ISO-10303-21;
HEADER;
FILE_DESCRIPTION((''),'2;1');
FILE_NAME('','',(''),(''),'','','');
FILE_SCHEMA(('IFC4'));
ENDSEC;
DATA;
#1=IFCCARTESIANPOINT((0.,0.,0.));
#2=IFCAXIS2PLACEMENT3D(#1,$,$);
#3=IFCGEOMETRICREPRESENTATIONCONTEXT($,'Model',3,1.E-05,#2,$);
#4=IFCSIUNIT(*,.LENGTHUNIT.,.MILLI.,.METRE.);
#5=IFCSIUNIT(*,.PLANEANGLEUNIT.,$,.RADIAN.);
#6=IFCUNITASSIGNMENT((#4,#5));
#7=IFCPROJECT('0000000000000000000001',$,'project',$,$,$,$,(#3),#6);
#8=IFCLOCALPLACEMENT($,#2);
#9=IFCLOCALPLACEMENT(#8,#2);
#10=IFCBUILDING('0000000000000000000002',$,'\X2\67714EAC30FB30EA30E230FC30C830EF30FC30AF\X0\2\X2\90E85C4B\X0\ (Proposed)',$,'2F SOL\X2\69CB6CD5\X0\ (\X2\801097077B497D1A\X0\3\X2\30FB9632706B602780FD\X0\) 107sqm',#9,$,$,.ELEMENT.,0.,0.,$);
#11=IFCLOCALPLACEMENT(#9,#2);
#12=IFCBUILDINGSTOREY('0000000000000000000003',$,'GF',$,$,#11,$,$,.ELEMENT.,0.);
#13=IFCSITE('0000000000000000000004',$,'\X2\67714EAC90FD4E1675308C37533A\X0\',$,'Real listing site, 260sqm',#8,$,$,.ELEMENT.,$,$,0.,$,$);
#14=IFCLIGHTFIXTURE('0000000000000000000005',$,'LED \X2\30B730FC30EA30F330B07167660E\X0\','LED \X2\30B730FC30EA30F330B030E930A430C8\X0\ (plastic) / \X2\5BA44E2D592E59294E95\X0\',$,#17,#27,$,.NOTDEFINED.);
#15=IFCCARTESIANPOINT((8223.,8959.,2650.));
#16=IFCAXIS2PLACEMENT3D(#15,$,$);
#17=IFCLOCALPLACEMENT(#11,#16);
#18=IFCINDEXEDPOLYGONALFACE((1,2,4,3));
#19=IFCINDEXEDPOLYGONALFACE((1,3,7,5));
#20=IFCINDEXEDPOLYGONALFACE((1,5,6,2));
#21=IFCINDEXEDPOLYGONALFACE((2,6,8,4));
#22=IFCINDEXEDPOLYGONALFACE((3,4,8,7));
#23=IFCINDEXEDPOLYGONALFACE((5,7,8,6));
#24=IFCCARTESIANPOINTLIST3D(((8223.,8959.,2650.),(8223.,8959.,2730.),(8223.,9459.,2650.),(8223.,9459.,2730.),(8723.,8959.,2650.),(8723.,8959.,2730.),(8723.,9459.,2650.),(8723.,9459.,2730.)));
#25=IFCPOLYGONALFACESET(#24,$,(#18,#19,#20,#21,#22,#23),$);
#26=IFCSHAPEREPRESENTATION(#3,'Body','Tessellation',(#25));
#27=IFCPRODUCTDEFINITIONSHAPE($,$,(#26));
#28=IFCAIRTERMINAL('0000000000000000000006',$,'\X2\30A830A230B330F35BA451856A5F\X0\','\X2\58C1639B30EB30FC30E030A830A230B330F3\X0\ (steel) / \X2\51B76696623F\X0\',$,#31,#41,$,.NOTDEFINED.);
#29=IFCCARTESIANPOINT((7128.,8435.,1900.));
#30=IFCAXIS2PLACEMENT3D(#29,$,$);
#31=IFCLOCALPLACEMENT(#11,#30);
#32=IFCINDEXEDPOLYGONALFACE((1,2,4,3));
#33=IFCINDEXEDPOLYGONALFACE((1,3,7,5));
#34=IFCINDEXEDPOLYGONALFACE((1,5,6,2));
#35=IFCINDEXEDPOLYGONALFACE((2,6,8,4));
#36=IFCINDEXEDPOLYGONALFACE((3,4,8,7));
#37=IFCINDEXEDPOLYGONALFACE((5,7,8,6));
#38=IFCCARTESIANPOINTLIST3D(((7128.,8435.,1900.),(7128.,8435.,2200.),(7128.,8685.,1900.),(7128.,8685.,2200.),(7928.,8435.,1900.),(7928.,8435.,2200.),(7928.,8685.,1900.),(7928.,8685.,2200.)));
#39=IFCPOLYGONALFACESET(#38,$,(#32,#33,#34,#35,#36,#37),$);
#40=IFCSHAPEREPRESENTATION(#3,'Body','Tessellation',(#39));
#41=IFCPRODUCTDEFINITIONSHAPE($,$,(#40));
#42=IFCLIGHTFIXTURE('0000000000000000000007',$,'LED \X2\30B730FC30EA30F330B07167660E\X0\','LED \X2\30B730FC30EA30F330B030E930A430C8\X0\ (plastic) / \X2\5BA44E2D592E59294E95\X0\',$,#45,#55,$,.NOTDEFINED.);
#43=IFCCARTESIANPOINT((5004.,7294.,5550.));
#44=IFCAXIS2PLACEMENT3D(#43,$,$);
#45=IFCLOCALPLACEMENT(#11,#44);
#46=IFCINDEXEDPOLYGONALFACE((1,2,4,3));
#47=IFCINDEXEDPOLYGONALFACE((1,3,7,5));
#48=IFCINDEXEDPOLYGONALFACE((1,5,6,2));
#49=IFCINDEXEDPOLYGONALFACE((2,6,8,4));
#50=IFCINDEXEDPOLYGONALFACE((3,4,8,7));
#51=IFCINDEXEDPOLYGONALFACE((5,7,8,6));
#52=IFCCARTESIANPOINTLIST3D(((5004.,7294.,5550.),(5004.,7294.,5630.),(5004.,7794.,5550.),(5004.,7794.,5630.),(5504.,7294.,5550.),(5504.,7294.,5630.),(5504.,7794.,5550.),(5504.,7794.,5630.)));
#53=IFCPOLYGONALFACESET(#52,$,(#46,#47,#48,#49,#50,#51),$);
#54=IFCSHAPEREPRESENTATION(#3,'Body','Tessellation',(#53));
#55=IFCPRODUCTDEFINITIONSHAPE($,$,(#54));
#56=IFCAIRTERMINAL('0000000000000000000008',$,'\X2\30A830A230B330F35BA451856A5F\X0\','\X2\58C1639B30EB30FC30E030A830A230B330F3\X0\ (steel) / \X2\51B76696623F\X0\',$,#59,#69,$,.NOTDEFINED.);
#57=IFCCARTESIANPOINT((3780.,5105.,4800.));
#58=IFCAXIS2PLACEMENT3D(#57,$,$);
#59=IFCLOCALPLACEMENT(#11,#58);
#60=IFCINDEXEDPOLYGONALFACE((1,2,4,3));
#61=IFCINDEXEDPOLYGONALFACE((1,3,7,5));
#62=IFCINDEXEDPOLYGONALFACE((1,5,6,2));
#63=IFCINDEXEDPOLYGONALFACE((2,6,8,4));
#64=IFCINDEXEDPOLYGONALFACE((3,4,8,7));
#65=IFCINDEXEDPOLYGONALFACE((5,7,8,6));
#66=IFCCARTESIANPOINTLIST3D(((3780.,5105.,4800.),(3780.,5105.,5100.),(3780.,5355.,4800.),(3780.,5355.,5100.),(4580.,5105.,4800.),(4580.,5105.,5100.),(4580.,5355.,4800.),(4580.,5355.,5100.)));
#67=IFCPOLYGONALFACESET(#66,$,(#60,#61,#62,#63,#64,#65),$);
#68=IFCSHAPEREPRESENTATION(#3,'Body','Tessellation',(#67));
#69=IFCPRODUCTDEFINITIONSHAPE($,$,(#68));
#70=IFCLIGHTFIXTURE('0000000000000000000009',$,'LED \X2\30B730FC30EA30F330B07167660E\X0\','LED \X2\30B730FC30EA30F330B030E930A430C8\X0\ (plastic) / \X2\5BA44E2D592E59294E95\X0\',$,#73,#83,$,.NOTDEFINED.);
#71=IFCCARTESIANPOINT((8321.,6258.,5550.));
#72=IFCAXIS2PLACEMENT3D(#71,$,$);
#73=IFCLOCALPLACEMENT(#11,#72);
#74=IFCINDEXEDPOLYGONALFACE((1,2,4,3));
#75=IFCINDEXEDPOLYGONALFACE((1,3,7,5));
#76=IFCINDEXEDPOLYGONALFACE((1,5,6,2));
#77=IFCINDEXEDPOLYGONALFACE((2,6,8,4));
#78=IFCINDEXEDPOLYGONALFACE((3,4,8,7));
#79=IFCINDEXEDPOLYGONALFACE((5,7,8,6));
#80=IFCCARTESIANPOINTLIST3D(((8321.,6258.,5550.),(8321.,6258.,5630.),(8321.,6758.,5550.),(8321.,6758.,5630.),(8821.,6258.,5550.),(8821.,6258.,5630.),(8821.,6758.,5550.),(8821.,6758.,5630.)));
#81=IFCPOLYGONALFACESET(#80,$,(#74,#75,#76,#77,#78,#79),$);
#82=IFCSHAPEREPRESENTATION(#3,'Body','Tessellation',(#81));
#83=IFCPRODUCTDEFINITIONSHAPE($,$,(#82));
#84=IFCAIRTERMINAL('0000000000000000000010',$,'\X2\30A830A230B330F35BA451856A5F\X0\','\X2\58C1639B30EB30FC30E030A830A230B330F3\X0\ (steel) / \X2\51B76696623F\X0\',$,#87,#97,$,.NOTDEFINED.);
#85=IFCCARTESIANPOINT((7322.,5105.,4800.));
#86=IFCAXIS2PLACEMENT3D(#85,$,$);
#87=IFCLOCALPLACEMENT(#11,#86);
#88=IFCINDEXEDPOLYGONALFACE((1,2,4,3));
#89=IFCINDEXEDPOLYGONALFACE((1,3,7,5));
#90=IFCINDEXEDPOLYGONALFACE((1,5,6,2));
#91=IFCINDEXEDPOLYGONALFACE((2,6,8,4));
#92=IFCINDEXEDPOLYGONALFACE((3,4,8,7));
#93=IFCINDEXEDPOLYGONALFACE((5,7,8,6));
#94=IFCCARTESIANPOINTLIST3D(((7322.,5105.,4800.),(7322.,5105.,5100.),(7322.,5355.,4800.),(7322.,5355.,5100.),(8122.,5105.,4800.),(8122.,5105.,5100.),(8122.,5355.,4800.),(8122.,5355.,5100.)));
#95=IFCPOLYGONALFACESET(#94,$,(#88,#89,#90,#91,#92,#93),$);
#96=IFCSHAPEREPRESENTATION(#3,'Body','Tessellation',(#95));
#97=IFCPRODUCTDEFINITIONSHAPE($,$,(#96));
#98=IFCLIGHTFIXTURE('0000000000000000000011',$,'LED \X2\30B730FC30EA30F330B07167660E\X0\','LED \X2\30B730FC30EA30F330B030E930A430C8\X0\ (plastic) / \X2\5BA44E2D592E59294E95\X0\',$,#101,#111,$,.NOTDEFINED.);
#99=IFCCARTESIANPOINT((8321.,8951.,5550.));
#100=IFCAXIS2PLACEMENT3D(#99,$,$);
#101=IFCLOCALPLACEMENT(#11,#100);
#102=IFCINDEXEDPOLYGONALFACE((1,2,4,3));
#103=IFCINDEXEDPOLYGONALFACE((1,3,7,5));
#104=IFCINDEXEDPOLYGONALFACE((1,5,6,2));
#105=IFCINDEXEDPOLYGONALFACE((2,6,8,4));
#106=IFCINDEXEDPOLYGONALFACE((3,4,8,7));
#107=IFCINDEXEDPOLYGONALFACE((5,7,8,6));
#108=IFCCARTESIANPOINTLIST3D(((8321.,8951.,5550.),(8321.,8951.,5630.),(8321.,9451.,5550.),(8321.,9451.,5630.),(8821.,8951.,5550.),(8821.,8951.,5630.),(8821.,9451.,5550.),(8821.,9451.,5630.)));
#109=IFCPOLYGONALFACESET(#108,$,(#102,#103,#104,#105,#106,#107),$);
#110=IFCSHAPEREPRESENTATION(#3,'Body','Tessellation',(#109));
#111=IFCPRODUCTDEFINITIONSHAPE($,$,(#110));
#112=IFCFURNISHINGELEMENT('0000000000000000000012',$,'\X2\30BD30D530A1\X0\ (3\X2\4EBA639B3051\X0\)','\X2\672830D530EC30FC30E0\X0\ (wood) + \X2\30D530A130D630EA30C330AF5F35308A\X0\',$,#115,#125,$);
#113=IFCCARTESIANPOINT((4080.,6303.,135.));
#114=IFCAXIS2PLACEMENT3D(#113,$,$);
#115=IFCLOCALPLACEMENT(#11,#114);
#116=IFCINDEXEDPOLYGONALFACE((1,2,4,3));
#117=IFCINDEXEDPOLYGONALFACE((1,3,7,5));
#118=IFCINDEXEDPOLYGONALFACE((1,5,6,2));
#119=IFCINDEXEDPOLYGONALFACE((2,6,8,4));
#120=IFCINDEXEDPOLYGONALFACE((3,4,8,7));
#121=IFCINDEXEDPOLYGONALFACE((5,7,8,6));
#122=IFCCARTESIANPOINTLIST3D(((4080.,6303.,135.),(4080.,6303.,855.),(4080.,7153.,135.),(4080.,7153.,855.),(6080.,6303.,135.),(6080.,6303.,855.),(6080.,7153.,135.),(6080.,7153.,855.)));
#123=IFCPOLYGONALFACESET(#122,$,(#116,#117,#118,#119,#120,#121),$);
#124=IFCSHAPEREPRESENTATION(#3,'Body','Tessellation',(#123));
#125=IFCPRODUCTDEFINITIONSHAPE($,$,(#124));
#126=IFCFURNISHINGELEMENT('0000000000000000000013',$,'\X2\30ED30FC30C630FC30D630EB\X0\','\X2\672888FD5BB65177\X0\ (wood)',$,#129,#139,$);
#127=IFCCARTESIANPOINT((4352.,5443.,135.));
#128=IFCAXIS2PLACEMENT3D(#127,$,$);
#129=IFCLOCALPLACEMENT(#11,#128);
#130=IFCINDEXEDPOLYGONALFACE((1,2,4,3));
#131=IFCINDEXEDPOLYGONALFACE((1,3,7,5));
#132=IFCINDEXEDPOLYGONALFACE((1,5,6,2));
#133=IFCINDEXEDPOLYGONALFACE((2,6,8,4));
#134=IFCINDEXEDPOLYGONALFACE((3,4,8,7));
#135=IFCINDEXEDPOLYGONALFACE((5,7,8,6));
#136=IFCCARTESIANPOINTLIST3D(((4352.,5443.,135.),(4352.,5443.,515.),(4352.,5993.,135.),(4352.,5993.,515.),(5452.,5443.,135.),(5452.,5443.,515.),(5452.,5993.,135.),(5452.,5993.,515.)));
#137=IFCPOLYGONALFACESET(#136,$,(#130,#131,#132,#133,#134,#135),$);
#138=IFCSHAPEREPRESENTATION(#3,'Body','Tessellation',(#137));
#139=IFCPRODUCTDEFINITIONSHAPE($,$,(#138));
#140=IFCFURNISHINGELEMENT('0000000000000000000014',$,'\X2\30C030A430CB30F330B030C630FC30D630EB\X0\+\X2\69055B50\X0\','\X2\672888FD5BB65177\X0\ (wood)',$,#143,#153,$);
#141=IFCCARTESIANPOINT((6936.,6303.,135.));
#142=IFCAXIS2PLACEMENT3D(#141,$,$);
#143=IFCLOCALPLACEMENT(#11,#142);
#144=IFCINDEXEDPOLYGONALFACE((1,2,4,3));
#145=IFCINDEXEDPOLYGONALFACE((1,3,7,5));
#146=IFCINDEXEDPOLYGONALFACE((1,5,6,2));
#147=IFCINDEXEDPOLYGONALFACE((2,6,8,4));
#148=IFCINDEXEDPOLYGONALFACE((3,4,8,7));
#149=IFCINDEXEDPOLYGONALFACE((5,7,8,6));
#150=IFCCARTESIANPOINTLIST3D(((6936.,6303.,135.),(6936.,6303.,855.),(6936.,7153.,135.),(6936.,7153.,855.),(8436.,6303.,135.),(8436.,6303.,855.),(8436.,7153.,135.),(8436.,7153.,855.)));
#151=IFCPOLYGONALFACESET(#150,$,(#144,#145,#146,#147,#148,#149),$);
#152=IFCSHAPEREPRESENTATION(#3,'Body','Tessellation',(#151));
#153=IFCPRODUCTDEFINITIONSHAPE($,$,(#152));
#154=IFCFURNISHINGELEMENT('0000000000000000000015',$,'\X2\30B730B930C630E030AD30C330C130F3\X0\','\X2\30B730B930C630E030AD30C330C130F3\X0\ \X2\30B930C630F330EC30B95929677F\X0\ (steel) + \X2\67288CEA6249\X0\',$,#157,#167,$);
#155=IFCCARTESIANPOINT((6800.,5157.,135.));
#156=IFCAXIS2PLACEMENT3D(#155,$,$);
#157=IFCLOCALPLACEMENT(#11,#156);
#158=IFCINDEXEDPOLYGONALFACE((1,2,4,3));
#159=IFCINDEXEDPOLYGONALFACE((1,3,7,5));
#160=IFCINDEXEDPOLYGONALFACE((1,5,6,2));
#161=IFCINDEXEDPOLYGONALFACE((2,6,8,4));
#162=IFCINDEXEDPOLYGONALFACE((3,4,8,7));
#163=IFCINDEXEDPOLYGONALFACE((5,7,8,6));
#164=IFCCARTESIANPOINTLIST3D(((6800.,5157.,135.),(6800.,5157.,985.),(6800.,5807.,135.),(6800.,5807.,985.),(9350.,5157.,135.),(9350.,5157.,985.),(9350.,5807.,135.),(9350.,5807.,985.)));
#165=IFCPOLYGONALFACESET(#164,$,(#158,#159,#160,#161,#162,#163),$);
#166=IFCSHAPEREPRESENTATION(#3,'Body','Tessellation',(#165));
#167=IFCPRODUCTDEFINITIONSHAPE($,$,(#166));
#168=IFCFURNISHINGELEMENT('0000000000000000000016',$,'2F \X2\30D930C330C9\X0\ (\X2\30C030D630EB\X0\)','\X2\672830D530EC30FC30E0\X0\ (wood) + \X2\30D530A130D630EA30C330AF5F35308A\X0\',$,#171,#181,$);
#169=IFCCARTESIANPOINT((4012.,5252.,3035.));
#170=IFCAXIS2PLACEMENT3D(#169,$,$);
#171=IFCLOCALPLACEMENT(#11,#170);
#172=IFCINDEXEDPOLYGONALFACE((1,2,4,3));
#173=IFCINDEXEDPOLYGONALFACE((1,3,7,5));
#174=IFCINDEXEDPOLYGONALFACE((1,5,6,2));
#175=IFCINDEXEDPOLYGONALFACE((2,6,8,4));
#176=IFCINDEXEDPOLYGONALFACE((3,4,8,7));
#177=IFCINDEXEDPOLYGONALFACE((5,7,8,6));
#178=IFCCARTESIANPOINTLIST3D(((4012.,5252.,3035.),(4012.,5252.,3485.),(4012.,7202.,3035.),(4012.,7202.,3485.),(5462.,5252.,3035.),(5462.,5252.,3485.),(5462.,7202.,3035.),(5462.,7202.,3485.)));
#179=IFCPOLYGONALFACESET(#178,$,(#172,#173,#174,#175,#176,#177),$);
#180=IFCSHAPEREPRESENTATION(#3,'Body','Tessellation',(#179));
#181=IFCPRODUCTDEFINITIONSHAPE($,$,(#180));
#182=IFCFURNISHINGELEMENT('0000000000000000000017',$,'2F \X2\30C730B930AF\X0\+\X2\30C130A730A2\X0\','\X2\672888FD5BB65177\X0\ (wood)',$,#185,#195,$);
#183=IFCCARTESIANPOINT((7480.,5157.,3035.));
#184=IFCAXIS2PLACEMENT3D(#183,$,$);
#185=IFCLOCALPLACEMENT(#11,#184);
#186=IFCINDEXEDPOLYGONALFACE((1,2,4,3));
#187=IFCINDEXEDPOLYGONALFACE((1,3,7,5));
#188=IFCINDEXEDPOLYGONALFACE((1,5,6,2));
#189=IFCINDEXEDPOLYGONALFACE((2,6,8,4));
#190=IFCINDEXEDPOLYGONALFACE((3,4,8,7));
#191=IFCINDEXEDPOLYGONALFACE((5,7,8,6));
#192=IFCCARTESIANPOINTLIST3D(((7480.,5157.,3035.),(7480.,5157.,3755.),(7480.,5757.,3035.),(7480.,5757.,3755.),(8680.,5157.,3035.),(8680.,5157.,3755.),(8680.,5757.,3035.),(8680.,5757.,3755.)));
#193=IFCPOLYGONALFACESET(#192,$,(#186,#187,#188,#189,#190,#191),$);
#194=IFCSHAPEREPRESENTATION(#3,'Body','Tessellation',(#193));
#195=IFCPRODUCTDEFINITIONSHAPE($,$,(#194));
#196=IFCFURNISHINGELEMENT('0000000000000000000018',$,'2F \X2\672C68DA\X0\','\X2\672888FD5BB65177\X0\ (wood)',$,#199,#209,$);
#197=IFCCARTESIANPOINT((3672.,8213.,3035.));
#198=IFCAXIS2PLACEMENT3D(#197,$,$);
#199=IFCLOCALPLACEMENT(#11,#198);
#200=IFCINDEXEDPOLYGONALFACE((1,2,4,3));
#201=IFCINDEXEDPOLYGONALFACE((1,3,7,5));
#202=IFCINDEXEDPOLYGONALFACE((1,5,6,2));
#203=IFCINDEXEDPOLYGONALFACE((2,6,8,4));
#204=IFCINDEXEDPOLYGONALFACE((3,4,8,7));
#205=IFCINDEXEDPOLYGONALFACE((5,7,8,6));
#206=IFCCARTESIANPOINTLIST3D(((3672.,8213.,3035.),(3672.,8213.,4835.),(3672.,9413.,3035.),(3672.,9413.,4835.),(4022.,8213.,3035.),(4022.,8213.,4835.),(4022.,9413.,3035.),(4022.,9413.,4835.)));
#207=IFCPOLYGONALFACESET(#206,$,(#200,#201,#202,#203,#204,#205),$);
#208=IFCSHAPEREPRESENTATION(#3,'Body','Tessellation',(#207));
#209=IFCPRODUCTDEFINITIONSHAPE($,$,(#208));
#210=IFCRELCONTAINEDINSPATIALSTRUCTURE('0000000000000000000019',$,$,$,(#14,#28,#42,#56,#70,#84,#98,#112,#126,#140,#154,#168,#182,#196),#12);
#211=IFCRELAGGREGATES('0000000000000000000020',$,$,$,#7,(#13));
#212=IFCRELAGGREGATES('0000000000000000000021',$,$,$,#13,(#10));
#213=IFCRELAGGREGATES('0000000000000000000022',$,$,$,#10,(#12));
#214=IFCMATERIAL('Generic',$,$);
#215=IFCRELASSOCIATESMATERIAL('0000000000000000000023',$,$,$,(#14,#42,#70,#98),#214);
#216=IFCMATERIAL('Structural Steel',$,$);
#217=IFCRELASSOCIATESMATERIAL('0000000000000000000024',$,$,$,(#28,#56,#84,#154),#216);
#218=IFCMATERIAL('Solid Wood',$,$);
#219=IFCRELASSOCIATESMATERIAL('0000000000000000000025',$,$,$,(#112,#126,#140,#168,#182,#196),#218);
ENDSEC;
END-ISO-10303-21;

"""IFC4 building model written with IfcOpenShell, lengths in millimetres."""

from ifc_helpers import new_model, si_unit, frame, frame_2d, origin, place, context, project, spatial, rectangle, extrude, material, element, save


model = new_model("IFC4")

# Units and contexts
model_context = context("Model", 3, precision=1e-05, world=origin())
ifc_project = project(units=[si_unit("LENGTHUNIT", "METRE", prefix="MILLI"), si_unit("PLANEANGLEUNIT", "RADIAN")], contexts=[model_context])

# Site, building, storey
site_placement = place(None, origin())
site = spatial("IfcSite", under=ifc_project, at=site_placement, Name="東京都世田谷区", ObjectType="Real listing site, 260sqm", CompositionType="ELEMENT", RefElevation=0.0)
building_placement = place(site_placement, origin())
building = spatial("IfcBuilding", under=site, at=building_placement, Name="東京・リモートワーク2部屋 (Proposed)", ObjectType="2F SOL構法 (耐震等級3・防火性能) 107sqm", CompositionType="ELEMENT", ElevationOfRefHeight=0.0, ElevationOfTerrain=0.0)
storey_placement = place(building_placement, origin())
storey = spatial("IfcBuildingStorey", under=building, at=storey_placement, Name="GF", CompositionType="ELEMENT", Elevation=0.0)

# Shared definitions
ifc_material_1 = material(Name="Solid Wood")

# Shared definitions
ifc_material_2 = material(Name="Structural Steel")

# Shared definitions
ifc_material_3 = material(Name="Generic")

# Light fixture
light_fixture_1_placement = place(storey_placement, frame((8223.0, 8959.0, 2650.0)))
element("IfcLightFixture", 1, at=light_fixture_1_placement, inside=storey, material=ifc_material_3, Name="LED シーリング照明", Description="LED シーリングライト (plastic) / 室中央天井", PredefinedType="NOTDEFINED", context=model_context, shape_type="SweptSolid", body=[
    extrude(rectangle(XDim=500.0, YDim=500.0, at=frame_2d((250.0, 250.0))), frame((8223.0, 8959.0, 2650.0)), (0.0, 0.0, 1.0), 80.0),
])

# Air terminal
air_terminal_1_placement = place(storey_placement, frame((7128.0, 8435.0, 1900.0)))
element("IfcAirTerminal", 2, at=air_terminal_1_placement, inside=storey, material=ifc_material_2, Name="エアコン室内機", Description="壁掛ルームエアコン (steel) / 冷暖房", PredefinedType="NOTDEFINED", context=model_context, shape_type="SweptSolid", body=[
    extrude(rectangle(XDim=800.0, YDim=250.0, at=frame_2d((400.0, 125.0))), frame((7128.0, 8435.0, 1900.0)), (0.0, 0.0, 1.0), 300.0),
])

# Light fixture
light_fixture_2_placement = place(storey_placement, frame((5004.0, 7294.0, 5550.0)))
element("IfcLightFixture", 3, at=light_fixture_2_placement, inside=storey, material=ifc_material_3, Name="LED シーリング照明", Description="LED シーリングライト (plastic) / 室中央天井", PredefinedType="NOTDEFINED", context=model_context, shape_type="SweptSolid", body=[
    extrude(rectangle(XDim=500.0, YDim=500.0, at=frame_2d((250.0, 250.0))), frame((5004.0, 7294.0, 5550.0)), (0.0, 0.0, 1.0), 80.0),
])

# Air terminal
air_terminal_2_placement = place(storey_placement, frame((3780.0, 5105.0, 4800.0)))
element("IfcAirTerminal", 4, at=air_terminal_2_placement, inside=storey, material=ifc_material_2, Name="エアコン室内機", Description="壁掛ルームエアコン (steel) / 冷暖房", PredefinedType="NOTDEFINED", context=model_context, shape_type="SweptSolid", body=[
    extrude(rectangle(XDim=800.0, YDim=250.0, at=frame_2d((400.0, 125.0))), frame((3780.0, 5105.0, 4800.0)), (0.0, 0.0, 1.0), 300.0),
])

# Light fixture
light_fixture_3_placement = place(storey_placement, frame((8321.0, 6258.0, 5550.0)))
element("IfcLightFixture", 5, at=light_fixture_3_placement, inside=storey, material=ifc_material_3, Name="LED シーリング照明", Description="LED シーリングライト (plastic) / 室中央天井", PredefinedType="NOTDEFINED", context=model_context, shape_type="SweptSolid", body=[
    extrude(rectangle(XDim=500.0, YDim=500.0, at=frame_2d((250.0, 250.0))), frame((8321.0, 6258.0, 5550.0)), (0.0, 0.0, 1.0), 80.0),
])

# Air terminal
air_terminal_3_placement = place(storey_placement, frame((7322.0, 5105.0, 4800.0)))
element("IfcAirTerminal", 6, at=air_terminal_3_placement, inside=storey, material=ifc_material_2, Name="エアコン室内機", Description="壁掛ルームエアコン (steel) / 冷暖房", PredefinedType="NOTDEFINED", context=model_context, shape_type="SweptSolid", body=[
    extrude(rectangle(XDim=800.0, YDim=250.0, at=frame_2d((400.0, 125.0))), frame((7322.0, 5105.0, 4800.0)), (0.0, 0.0, 1.0), 300.0),
])

# Light fixture
light_fixture_4_placement = place(storey_placement, frame((8321.0, 8951.0, 5550.0)))
element("IfcLightFixture", 7, at=light_fixture_4_placement, inside=storey, material=ifc_material_3, Name="LED シーリング照明", Description="LED シーリングライト (plastic) / 室中央天井", PredefinedType="NOTDEFINED", context=model_context, shape_type="SweptSolid", body=[
    extrude(rectangle(XDim=500.0, YDim=500.0, at=frame_2d((250.0, 250.0))), frame((8321.0, 8951.0, 5550.0)), (0.0, 0.0, 1.0), 80.0),
])

# Furnishing elements
furnishing_1_placement = place(storey_placement, frame((4080.0, 6303.0, 135.0)))
element("IfcFurnishingElement", 8, at=furnishing_1_placement, inside=storey, material=ifc_material_1, Name="ソファ (3人掛け)", Description="木フレーム (wood) + ファブリック張り", context=model_context, shape_type="SweptSolid", body=[
    extrude(rectangle(XDim=2000.0, YDim=850.0, at=frame_2d((1000.0, 425.0))), frame((4080.0, 6303.0, 135.0)), (0.0, 0.0, 1.0), 720.0),
])
furnishing_2_placement = place(storey_placement, frame((4352.0, 5443.0, 135.0)))
element("IfcFurnishingElement", 9, at=furnishing_2_placement, inside=storey, material=ifc_material_1, Name="ローテーブル", Description="木製家具 (wood)", context=model_context, shape_type="SweptSolid", body=[
    extrude(rectangle(XDim=1100.0, YDim=550.0, at=frame_2d((550.0, 275.0))), frame((4352.0, 5443.0, 135.0)), (0.0, 0.0, 1.0), 380.0),
])
furnishing_3_placement = place(storey_placement, frame((6936.0, 6303.0, 135.0)))
element("IfcFurnishingElement", 10, at=furnishing_3_placement, inside=storey, material=ifc_material_1, Name="ダイニングテーブル+椅子", Description="木製家具 (wood)", context=model_context, shape_type="SweptSolid", body=[
    extrude(rectangle(XDim=1500.0, YDim=850.0, at=frame_2d((750.0, 425.0))), frame((6936.0, 6303.0, 135.0)), (0.0, 0.0, 1.0), 720.0),
])
furnishing_4_placement = place(storey_placement, frame((6800.0, 5157.0, 135.0)))
element("IfcFurnishingElement", 11, at=furnishing_4_placement, inside=storey, material=ifc_material_2, Name="システムキッチン", Description="システムキッチン ステンレス天板 (steel) + 木質扉", context=model_context, shape_type="SweptSolid", body=[
    extrude(rectangle(XDim=2550.0, YDim=650.0, at=frame_2d((1275.0, 325.0))), frame((6800.0, 5157.0, 135.0)), (0.0, 0.0, 1.0), 850.0),
])
furnishing_5_placement = place(storey_placement, frame((4012.0, 5252.0, 3035.0)))
element("IfcFurnishingElement", 12, at=furnishing_5_placement, inside=storey, material=ifc_material_1, Name="2F ベッド (ダブル)", Description="木フレーム (wood) + ファブリック張り", context=model_context, shape_type="SweptSolid", body=[
    extrude(rectangle(XDim=1450.0, YDim=1950.0, at=frame_2d((725.0, 975.0))), frame((4012.0, 5252.0, 3035.0)), (0.0, 0.0, 1.0), 450.0),
])
furnishing_6_placement = place(storey_placement, frame((7480.0, 5157.0, 3035.0)))
element("IfcFurnishingElement", 13, at=furnishing_6_placement, inside=storey, material=ifc_material_1, Name="2F デスク+チェア", Description="木製家具 (wood)", context=model_context, shape_type="SweptSolid", body=[
    extrude(rectangle(XDim=1200.0, YDim=600.0, at=frame_2d((600.0, 300.0))), frame((7480.0, 5157.0, 3035.0)), (0.0, 0.0, 1.0), 720.0),
])
furnishing_7_placement = place(storey_placement, frame((3672.0, 8213.0, 3035.0)))
element("IfcFurnishingElement", 14, at=furnishing_7_placement, inside=storey, material=ifc_material_1, Name="2F 本棚", Description="木製家具 (wood)", context=model_context, shape_type="SweptSolid", body=[
    extrude(rectangle(XDim=350.0, YDim=1200.0, at=frame_2d((175.0, 600.0))), frame((3672.0, 8213.0, 3035.0)), (0.0, 0.0, 1.0), 1800.0),
])

save(model, "model.ifc")
